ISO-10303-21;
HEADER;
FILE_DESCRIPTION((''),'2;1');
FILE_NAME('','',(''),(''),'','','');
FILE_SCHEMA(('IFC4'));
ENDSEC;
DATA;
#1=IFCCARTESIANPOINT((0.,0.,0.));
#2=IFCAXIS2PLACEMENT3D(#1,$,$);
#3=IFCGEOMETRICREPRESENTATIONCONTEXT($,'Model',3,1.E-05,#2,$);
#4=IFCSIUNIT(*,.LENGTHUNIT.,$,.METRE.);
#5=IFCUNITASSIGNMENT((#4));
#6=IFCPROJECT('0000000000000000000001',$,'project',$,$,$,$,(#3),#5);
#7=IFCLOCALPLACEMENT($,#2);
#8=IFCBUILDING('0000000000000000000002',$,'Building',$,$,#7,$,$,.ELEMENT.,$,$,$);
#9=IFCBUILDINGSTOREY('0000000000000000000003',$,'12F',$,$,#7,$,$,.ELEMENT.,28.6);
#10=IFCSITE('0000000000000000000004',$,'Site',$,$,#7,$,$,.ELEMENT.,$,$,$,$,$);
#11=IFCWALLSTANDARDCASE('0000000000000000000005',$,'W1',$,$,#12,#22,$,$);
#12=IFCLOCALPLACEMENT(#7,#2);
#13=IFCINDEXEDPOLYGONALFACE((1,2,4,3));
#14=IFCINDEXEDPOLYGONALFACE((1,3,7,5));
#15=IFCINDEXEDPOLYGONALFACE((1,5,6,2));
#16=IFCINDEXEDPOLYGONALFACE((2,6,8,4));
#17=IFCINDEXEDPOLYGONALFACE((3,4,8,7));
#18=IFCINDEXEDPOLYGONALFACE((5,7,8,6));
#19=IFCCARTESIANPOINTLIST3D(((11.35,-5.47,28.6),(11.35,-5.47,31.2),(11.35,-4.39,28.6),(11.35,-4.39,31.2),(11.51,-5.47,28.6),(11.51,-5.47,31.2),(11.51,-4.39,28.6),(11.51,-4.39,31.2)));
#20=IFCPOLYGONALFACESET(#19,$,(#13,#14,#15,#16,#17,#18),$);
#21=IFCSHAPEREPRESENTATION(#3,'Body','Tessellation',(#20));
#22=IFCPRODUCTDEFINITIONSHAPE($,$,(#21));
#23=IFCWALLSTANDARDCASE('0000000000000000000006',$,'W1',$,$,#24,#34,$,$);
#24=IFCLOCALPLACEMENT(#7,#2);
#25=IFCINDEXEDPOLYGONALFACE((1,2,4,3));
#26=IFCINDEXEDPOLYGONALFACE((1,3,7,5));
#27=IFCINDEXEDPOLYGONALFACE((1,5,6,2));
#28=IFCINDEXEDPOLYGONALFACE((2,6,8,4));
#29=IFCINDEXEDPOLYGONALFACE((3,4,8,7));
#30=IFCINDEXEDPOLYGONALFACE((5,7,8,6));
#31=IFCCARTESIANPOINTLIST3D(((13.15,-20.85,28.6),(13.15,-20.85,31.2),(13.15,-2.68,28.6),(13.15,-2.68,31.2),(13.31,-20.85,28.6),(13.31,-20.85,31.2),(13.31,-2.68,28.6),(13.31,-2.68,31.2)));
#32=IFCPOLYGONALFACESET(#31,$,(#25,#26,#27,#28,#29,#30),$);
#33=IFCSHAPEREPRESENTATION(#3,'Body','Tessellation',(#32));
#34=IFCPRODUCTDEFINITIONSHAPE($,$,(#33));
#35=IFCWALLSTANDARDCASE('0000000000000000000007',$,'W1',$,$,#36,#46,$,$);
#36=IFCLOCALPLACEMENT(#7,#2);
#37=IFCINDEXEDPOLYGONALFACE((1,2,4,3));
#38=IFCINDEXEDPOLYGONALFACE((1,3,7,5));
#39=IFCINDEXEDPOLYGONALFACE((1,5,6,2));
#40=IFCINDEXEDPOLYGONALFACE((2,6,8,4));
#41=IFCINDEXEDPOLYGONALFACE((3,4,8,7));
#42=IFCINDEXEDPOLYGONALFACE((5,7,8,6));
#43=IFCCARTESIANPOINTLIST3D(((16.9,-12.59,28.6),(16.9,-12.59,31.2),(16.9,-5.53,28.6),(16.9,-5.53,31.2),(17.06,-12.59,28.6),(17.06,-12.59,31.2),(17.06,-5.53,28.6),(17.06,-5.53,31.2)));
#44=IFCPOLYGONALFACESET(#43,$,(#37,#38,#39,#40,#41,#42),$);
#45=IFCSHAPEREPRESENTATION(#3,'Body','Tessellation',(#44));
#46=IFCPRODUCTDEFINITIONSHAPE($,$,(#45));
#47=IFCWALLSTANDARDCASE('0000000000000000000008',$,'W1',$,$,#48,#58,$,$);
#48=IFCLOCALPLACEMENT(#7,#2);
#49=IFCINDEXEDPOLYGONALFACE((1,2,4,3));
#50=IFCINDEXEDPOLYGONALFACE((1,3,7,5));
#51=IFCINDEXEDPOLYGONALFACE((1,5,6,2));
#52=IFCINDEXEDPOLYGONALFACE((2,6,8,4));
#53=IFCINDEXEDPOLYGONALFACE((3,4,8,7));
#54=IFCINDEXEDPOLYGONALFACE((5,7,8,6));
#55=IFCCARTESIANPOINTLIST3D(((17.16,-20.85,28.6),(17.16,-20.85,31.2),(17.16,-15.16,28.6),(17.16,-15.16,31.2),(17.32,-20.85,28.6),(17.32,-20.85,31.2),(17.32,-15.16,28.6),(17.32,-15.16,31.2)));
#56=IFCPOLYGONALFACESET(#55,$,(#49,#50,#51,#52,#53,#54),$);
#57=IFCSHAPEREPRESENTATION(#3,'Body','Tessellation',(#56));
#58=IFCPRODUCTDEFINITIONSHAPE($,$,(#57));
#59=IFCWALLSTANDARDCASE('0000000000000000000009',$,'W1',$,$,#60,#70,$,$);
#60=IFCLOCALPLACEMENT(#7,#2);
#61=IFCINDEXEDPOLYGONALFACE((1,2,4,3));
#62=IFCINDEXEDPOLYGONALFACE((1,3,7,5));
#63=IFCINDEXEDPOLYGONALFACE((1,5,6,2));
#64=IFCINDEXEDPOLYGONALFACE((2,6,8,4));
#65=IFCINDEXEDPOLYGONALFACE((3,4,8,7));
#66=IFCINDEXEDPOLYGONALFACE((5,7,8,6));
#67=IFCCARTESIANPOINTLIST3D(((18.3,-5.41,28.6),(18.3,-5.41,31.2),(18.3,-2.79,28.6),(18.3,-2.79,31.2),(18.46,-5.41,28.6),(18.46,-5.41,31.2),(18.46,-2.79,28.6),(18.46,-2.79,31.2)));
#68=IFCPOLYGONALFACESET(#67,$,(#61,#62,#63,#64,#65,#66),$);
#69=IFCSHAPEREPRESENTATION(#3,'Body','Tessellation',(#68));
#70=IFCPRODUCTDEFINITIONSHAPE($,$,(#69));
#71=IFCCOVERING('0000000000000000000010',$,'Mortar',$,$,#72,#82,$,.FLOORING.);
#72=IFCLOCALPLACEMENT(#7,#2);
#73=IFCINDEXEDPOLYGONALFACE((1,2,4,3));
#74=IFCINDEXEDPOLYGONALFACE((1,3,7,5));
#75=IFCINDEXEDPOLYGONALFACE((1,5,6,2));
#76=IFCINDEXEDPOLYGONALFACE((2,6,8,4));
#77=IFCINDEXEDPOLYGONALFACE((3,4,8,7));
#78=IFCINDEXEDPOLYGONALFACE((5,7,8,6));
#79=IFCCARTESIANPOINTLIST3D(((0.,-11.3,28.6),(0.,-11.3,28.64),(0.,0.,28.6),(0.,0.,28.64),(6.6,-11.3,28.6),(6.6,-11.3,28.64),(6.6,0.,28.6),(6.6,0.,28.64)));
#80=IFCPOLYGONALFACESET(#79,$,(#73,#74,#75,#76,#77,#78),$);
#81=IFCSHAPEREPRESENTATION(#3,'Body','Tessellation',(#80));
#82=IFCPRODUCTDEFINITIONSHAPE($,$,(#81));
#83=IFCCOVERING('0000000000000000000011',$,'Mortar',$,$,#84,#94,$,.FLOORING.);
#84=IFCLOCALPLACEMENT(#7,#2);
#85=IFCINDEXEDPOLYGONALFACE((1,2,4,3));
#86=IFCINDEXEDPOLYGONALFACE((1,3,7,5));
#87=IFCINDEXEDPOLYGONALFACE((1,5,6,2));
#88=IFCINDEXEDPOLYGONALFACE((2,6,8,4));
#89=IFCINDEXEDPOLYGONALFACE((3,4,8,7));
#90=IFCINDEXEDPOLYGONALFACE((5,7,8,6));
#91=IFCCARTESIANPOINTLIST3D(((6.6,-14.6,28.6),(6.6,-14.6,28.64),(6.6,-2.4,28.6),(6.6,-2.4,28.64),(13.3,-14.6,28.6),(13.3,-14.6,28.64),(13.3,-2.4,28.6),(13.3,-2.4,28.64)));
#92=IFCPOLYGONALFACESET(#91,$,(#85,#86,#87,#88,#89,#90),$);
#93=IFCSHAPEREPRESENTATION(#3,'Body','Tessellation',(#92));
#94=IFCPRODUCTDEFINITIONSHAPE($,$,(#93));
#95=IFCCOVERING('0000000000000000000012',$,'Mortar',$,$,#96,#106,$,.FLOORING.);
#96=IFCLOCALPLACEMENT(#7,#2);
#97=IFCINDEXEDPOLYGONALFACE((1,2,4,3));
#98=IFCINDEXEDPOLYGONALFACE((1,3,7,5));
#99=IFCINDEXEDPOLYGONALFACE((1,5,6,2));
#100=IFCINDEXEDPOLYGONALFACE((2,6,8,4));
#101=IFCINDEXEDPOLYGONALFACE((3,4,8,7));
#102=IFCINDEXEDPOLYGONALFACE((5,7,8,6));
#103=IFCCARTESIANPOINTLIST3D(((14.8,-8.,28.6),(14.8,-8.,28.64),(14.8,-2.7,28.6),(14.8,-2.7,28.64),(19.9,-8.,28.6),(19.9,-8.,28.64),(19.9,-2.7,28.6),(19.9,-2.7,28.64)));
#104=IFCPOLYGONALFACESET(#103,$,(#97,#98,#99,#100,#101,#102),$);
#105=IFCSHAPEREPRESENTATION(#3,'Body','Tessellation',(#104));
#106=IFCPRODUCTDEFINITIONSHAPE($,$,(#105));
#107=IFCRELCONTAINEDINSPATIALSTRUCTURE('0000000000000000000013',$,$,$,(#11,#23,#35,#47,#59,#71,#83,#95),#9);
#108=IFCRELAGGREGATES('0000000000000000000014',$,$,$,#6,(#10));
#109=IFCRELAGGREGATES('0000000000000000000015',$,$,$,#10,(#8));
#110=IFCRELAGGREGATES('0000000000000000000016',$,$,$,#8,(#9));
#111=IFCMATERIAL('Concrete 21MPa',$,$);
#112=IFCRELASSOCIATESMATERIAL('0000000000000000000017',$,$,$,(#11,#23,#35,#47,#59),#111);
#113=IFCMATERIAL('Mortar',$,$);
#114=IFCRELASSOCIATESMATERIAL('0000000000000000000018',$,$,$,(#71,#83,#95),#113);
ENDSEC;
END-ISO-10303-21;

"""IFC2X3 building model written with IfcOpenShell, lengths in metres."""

from ifc_helpers import new_model, si_unit, frame, origin, origin_2d, place, context, project, spatial, rectangle, extrude, material, element, save


model = new_model("IFC2X3")

# Units and contexts
model_context = context("Model", 3, precision=1e-05, world=origin())
ifc_project = project(units=[si_unit("LENGTHUNIT", "METRE")], contexts=[model_context])

# Site, building, storey
placement = place(None, origin())
site = spatial("IfcSite", under=ifc_project, at=placement, Name="Site", CompositionType="ELEMENT")
building = spatial("IfcBuilding", under=site, at=placement, Name="Building", CompositionType="ELEMENT")
storey = spatial("IfcBuildingStorey", under=building, at=placement, Name="12F", CompositionType="ELEMENT", Elevation=28.6)

# Shared definitions
ifc_material_1 = material(Name="Concrete 21MPa")

# Walls
wall_1_placement = place(None, frame((11.43, -4.93, 28.6)))
element("IfcWallStandardCase", 1, at=wall_1_placement, inside=storey, material=ifc_material_1, Name="W1", context=model_context, shape_type="SweptSolid", body=[
    extrude(rectangle(XDim=0.16, YDim=1.08, at=origin_2d()), origin(), (0.0, 0.0, 1.0), 2.6),
])
wall_2_placement = place(None, frame((13.23, -11.765, 28.6)))
element("IfcWallStandardCase", 2, at=wall_2_placement, inside=storey, material=ifc_material_1, Name="W1", context=model_context, shape_type="SweptSolid", body=[
    extrude(rectangle(XDim=0.16, YDim=18.17, at=origin_2d()), origin(), (0.0, 0.0, 1.0), 2.6),
])
wall_3_placement = place(None, frame((16.98, -9.06, 28.6)))
element("IfcWallStandardCase", 3, at=wall_3_placement, inside=storey, material=ifc_material_1, Name="W1", context=model_context, shape_type="SweptSolid", body=[
    extrude(rectangle(XDim=0.16, YDim=7.06, at=origin_2d()), origin(), (0.0, 0.0, 1.0), 2.6),
])
wall_4_placement = place(None, frame((17.24, -18.005, 28.6)))
element("IfcWallStandardCase", 4, at=wall_4_placement, inside=storey, material=ifc_material_1, Name="W1", context=model_context, shape_type="SweptSolid", body=[
    extrude(rectangle(XDim=0.16, YDim=5.69, at=origin_2d()), origin(), (0.0, 0.0, 1.0), 2.6),
])
wall_5_placement = place(None, frame((18.38, -4.1, 28.6)))
element("IfcWallStandardCase", 5, at=wall_5_placement, inside=storey, material=ifc_material_1, Name="W1", context=model_context, shape_type="SweptSolid", body=[
    extrude(rectangle(XDim=0.16, YDim=2.62, at=origin_2d()), origin(), (0.0, 0.0, 1.0), 2.6),
])

# Coverings
ifc_material_2 = material(Name="Mortar")
covering_1_placement = place(None, frame((3.3, -5.65, 28.6)))
element("IfcCovering", 6, at=covering_1_placement, inside=storey, material=ifc_material_2, Name="Mortar", PredefinedType="FLOORING", context=model_context, shape_type="SweptSolid", body=[
    extrude(rectangle(XDim=6.6, YDim=11.3, at=origin_2d()), origin(), (0.0, 0.0, 1.0), 0.04),
])
covering_2_placement = place(None, frame((9.95, -8.5, 28.6)))
element("IfcCovering", 7, at=covering_2_placement, inside=storey, material=ifc_material_2, Name="Mortar", PredefinedType="FLOORING", context=model_context, shape_type="SweptSolid", body=[
    extrude(rectangle(XDim=6.7, YDim=12.2, at=origin_2d()), origin(), (0.0, 0.0, 1.0), 0.04),
])
covering_3_placement = place(None, frame((17.35, -5.35, 28.6)))
element("IfcCovering", 8, at=covering_3_placement, inside=storey, material=ifc_material_2, Name="Mortar", PredefinedType="FLOORING", context=model_context, shape_type="SweptSolid", body=[
    extrude(rectangle(XDim=5.1, YDim=5.3, at=origin_2d()), origin(), (0.0, 0.0, 1.0), 0.04),
])

save(model, "model.ifc")
